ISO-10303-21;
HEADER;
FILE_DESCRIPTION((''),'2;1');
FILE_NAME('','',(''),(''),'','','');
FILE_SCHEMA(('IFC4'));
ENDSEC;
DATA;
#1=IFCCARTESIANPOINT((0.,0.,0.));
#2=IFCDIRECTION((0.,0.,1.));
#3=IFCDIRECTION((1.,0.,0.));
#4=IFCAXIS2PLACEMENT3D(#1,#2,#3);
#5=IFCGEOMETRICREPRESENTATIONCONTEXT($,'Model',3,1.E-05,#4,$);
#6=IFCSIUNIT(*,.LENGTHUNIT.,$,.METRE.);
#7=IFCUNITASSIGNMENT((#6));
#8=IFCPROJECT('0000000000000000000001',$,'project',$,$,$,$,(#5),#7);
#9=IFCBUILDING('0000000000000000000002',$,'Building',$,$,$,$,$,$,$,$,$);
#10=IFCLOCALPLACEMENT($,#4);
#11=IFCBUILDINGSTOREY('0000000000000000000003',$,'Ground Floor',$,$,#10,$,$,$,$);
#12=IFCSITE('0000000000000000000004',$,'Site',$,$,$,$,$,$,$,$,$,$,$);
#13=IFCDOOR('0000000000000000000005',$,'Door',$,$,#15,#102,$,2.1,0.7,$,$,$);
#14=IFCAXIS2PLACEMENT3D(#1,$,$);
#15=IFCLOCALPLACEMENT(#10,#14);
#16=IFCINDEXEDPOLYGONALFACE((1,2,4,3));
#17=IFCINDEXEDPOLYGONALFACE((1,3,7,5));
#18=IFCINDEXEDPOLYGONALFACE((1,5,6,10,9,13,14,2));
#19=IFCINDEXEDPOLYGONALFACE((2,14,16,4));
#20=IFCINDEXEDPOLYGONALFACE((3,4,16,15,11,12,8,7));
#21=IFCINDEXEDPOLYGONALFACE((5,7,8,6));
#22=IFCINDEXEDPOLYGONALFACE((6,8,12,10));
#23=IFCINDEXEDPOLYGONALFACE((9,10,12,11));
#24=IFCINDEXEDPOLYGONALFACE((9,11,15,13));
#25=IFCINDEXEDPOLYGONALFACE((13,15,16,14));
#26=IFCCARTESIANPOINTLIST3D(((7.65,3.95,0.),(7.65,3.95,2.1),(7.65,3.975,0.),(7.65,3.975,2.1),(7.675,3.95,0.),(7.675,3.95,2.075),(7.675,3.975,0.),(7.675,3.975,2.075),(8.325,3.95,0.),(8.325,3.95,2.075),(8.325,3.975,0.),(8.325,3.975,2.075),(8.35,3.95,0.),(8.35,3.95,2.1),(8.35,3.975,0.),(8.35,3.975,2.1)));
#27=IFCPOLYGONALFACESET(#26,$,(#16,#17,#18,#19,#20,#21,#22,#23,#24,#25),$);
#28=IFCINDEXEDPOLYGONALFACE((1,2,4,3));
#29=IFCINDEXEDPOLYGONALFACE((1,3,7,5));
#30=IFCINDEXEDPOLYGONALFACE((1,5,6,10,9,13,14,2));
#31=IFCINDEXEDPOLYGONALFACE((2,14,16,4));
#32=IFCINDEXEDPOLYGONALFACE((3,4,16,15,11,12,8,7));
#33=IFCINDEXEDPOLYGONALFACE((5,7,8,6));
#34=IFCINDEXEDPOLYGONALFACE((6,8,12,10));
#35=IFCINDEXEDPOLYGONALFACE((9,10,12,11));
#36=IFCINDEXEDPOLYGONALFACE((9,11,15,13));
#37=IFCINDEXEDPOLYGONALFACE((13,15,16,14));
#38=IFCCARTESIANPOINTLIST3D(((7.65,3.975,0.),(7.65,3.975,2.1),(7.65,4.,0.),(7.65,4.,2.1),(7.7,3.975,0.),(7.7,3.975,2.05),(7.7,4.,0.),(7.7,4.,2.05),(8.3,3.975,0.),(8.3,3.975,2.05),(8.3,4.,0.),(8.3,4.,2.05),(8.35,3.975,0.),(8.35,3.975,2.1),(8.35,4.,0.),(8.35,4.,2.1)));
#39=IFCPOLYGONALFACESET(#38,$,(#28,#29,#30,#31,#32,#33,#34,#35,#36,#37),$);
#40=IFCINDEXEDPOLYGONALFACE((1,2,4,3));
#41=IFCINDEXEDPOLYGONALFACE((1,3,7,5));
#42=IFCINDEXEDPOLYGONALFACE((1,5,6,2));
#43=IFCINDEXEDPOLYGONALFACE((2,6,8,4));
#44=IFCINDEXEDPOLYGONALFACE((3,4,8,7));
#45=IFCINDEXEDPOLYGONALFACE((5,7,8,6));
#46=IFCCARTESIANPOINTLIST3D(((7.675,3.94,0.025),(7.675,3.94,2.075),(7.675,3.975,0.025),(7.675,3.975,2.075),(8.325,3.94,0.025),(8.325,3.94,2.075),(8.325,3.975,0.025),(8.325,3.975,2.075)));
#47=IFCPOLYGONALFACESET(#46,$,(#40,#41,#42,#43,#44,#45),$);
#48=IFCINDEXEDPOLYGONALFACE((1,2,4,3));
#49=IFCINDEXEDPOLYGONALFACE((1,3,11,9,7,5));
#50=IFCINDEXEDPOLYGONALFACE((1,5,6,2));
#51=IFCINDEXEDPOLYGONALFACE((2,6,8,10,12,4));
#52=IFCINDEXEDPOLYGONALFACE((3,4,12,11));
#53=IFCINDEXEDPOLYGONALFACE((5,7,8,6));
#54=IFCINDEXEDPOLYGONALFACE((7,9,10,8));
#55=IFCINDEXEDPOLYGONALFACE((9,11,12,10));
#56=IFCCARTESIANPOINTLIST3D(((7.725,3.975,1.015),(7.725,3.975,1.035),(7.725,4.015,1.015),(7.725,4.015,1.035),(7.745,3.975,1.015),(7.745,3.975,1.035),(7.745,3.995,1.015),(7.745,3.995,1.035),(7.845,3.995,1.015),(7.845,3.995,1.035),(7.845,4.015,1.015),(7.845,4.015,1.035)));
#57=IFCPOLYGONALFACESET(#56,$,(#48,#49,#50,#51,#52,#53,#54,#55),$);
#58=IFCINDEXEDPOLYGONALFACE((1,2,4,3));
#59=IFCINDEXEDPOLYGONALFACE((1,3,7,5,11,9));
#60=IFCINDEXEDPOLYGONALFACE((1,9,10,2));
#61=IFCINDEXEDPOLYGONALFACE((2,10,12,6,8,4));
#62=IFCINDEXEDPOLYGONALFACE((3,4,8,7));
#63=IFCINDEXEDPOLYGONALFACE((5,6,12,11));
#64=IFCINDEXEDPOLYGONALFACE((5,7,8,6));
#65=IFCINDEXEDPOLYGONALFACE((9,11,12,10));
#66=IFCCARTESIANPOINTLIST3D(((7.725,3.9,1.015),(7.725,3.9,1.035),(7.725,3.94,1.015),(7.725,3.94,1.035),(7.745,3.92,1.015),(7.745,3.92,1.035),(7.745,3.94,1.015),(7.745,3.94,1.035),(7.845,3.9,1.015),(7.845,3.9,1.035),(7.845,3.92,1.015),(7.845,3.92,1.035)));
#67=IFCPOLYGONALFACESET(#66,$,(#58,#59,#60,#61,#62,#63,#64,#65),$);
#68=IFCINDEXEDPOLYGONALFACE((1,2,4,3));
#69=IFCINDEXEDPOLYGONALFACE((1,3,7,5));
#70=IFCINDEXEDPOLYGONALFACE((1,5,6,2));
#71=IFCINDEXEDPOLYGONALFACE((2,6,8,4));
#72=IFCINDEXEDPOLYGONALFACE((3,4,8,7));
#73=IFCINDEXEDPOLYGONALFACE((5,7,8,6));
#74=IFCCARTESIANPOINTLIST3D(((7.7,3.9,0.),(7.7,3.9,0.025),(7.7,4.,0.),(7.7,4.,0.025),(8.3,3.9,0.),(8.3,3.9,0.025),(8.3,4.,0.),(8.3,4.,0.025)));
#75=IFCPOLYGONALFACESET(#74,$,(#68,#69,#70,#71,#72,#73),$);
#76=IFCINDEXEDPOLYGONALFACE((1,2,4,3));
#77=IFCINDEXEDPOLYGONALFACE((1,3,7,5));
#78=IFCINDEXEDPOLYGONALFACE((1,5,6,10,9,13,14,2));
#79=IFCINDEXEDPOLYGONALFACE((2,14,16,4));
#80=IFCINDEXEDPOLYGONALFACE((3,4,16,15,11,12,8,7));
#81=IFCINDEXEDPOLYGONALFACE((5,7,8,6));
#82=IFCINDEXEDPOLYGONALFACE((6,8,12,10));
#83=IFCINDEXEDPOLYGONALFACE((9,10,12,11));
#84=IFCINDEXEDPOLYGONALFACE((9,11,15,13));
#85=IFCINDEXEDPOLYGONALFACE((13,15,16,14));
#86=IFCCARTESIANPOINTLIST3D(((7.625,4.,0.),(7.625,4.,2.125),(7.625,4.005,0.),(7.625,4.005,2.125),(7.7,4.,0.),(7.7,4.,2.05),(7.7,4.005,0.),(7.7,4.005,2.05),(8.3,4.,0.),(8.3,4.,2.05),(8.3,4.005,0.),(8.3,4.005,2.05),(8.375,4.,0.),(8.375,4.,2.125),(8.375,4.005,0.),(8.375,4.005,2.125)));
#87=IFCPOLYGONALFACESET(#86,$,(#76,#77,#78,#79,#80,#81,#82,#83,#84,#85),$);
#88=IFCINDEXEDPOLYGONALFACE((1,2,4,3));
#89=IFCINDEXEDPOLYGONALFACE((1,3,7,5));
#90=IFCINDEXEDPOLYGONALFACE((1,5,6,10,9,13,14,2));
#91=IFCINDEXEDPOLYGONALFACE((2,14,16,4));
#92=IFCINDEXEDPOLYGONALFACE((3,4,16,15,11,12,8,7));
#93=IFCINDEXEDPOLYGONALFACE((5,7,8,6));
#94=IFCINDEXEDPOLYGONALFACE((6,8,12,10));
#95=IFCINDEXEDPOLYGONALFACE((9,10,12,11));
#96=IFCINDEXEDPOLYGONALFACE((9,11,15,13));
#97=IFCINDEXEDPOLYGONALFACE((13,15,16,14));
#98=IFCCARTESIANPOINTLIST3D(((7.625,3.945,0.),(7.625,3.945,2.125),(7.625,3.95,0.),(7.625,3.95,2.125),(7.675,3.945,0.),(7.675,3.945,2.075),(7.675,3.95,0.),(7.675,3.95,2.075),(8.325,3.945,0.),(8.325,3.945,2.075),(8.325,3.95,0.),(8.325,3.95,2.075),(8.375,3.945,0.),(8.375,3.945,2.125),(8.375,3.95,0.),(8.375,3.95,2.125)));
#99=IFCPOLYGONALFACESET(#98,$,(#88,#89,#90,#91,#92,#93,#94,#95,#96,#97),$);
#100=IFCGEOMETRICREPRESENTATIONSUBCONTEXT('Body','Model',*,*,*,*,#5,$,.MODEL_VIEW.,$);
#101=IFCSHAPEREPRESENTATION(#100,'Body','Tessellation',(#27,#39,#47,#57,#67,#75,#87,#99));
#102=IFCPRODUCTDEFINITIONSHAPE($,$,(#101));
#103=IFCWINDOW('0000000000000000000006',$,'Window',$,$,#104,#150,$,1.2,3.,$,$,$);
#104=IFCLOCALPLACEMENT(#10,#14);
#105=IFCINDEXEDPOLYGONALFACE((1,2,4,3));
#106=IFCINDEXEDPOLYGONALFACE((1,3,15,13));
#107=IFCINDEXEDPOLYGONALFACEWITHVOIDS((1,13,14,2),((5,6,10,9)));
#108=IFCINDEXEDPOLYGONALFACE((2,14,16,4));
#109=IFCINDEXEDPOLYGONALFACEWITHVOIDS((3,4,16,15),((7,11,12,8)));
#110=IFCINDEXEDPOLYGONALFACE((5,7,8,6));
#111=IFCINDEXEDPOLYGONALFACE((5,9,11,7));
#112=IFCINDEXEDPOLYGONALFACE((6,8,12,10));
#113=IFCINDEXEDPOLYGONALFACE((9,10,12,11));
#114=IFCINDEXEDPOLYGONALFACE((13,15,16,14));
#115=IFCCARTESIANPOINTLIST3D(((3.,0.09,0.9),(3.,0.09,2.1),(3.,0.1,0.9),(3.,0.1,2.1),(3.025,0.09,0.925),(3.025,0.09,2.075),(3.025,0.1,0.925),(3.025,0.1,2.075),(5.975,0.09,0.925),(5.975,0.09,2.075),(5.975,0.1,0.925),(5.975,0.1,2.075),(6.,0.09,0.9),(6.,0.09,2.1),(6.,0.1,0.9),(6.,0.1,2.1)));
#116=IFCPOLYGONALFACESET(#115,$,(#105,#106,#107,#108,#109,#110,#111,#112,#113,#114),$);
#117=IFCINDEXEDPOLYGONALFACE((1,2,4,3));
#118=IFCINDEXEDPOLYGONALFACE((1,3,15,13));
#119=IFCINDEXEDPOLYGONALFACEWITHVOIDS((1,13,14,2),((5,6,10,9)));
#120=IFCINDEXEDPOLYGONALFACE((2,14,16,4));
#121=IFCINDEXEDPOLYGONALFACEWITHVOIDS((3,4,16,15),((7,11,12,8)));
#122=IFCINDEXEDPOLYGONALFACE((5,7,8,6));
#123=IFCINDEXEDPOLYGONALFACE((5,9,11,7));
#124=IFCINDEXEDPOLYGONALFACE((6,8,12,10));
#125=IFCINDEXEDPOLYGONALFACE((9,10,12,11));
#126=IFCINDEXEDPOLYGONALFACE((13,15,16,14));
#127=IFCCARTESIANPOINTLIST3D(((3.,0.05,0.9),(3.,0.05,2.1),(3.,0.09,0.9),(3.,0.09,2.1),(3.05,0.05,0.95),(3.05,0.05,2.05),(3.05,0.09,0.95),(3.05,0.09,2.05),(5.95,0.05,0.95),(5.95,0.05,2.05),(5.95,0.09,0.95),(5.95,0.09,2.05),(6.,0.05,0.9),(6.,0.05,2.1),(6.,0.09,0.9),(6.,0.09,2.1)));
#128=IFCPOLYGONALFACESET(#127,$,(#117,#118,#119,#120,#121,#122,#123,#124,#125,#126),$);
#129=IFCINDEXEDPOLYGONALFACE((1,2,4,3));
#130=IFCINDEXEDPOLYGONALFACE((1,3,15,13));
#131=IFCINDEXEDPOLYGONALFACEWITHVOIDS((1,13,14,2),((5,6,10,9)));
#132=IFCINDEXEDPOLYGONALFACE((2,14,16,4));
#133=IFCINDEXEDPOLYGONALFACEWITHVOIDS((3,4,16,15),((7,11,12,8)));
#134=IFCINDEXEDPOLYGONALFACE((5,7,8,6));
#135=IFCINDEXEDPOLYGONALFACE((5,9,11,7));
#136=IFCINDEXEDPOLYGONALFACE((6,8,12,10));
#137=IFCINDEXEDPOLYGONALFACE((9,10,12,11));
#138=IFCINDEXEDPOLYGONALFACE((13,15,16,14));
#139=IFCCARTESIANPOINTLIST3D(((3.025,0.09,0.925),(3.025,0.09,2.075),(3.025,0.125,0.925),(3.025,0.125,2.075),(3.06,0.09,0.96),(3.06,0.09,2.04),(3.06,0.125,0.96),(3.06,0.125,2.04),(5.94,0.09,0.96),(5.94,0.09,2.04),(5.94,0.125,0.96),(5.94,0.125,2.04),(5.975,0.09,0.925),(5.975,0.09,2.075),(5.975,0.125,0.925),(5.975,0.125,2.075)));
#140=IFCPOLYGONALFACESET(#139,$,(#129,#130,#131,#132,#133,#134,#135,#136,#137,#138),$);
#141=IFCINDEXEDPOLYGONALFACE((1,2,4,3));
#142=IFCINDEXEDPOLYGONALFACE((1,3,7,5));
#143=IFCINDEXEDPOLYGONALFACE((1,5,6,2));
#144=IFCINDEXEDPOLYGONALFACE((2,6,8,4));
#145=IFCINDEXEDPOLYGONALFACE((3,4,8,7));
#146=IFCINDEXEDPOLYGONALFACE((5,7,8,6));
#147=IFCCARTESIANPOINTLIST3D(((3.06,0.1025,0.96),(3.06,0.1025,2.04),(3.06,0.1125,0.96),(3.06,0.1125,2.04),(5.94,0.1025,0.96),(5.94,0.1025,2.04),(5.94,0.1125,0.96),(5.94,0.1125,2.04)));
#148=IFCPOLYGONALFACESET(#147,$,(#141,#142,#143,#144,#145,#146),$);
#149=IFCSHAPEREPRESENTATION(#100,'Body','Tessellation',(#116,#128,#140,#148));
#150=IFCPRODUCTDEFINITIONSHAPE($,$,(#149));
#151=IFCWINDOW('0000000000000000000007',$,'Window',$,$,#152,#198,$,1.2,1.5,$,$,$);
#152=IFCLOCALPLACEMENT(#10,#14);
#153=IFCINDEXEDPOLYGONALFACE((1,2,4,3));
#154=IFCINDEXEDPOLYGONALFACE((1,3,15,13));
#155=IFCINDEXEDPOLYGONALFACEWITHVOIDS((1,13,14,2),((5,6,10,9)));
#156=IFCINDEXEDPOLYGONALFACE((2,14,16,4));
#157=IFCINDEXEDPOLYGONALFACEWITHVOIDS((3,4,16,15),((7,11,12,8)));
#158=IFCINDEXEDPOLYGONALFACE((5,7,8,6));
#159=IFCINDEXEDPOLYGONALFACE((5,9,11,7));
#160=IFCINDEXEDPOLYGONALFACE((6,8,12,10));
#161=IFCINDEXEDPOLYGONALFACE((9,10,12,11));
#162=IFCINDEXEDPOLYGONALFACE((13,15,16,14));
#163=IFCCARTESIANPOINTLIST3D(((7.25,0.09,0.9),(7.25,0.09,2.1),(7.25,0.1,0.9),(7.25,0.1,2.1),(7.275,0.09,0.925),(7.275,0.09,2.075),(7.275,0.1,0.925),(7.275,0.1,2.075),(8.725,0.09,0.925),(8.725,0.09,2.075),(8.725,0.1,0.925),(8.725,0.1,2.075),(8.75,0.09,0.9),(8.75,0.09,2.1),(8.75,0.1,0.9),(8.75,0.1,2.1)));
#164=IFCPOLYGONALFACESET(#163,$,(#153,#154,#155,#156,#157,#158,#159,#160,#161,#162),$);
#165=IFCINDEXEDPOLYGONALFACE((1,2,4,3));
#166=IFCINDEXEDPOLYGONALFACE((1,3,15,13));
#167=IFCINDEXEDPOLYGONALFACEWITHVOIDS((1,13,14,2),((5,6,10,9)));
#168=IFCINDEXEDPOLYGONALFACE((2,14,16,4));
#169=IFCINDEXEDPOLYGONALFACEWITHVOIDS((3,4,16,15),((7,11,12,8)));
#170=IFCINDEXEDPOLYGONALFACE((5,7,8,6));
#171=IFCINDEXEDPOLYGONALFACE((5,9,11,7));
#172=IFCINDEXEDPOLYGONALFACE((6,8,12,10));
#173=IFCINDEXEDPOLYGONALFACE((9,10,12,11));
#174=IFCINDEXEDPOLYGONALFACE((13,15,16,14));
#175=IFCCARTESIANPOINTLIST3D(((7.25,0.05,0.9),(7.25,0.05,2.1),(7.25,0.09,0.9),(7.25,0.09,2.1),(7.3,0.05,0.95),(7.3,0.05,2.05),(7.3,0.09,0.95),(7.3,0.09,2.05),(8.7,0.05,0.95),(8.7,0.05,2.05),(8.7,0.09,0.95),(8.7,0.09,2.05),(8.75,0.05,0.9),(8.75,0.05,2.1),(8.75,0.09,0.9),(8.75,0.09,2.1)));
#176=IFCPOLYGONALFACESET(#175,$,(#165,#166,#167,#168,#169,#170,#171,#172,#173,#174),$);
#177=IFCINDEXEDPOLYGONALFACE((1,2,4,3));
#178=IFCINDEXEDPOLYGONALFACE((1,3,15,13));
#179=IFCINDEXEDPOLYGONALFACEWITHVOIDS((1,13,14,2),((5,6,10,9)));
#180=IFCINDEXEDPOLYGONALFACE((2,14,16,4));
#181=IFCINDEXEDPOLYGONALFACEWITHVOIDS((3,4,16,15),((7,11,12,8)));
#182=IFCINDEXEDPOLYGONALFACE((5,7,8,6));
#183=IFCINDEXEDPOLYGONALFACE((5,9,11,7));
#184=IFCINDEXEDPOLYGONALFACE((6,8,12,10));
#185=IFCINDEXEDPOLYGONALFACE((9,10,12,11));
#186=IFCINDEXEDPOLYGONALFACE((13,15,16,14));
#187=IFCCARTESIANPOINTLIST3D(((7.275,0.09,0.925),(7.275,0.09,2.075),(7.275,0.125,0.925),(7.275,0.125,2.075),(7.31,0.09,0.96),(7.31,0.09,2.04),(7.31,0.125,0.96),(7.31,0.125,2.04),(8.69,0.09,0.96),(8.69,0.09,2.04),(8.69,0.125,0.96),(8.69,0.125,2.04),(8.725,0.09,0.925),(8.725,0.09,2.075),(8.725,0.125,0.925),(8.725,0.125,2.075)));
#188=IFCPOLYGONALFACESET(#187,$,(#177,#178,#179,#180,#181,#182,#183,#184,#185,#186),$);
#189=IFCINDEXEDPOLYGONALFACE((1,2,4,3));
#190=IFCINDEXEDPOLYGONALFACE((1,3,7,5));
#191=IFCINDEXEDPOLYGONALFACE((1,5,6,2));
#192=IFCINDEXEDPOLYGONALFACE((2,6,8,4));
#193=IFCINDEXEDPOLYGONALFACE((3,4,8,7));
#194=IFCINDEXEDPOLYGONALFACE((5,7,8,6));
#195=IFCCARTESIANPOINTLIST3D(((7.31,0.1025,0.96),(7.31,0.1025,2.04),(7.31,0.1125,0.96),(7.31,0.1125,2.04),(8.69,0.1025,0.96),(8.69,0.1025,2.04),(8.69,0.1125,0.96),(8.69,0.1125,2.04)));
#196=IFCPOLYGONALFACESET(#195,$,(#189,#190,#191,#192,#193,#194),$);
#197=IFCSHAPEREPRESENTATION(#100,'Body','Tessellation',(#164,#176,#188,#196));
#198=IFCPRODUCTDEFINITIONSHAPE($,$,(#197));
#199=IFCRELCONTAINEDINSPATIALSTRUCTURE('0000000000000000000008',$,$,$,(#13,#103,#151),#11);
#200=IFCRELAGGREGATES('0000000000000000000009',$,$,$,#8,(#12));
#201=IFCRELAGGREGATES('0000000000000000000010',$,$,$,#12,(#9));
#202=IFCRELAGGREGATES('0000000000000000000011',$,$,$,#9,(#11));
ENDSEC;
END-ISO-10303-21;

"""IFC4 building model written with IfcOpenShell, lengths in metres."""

from ifc_helpers import new_model, si_unit, frame, origin_with_axes, place, context, subcontext, project, spatial, line, indexed_curve, outline, extrude, element, save


model = new_model("IFC4")

# Units and contexts
model_context = context("Model", 3, precision=1e-05, world=origin_with_axes())
body_context = subcontext(model_context, "Body", "Model", "MODEL_VIEW")
ifc_project = project(units=[si_unit("LENGTHUNIT", "METRE")], contexts=[model_context])

# Site, building, storey
site = spatial("IfcSite", under=ifc_project, Name="Site")
building = spatial("IfcBuilding", under=site, Name="Building")
storey_placement = place(None, origin_with_axes())
storey = spatial("IfcBuildingStorey", under=building, at=storey_placement, Name="Ground Floor")

# Door
door_1_placement = place(storey_placement, frame((8.35, 4.0, 0.0), z_axis=(0.0, 0.0, 1.0), x_axis=(-1.0, 0.0, 0.0)))
element("IfcDoor", 1, at=door_1_placement, inside=storey, Name="Door", OverallHeight=2.1, OverallWidth=0.7, context=body_context, shape_type="SweptSolid", body=[
    extrude(outline(indexed_curve([(0.0, 0.0), (0.0, 2.1), (0.7, 2.1), (0.7, 0.0), (0.675, 0.0), (0.675, 2.075), (0.025, 2.075), (0.025, 0.0)], segments=[line(1, 2, 3, 4, 5, 6, 7, 8, 1)])), frame((0.0, 0.025, 0.0), z_axis=(0.0, -1.0, 0.0), x_axis=(1.0, 0.0, 0.0)), (0.0, 0.0, -1.0), 0.025),
    extrude(outline(indexed_curve([(0.0, 0.0), (0.0, 2.1), (0.7, 2.1), (0.7, 0.0), (0.65, 0.0), (0.65, 2.05), (0.05, 2.05), (0.05, 0.0)], segments=[line(1, 2, 3, 4, 5, 6, 7, 8, 1)])), frame((0.0, 0.0, 0.0), z_axis=(0.0, -1.0, 0.0), x_axis=(1.0, 0.0, 0.0)), (0.0, 0.0, -1.0), 0.025),
    extrude(outline(indexed_curve([(0.0, 0.0), (0.65, 0.0), (0.65, 0.035), (0.0, 0.035)], segments=[line(1, 2, 3, 4, 1)])), frame((0.025, 0.025, 0.025), z_axis=(0.0, 0.0, 1.0), x_axis=(1.0, 0.0, 0.0)), (0.0, 0.0, 1.0), 2.05),
    extrude(outline(indexed_curve([(0.0, 0.0), (0.0, -0.04), (-0.12, -0.04), (-0.12, -0.02), (-0.02, -0.02), (-0.02, 0.0)], segments=[line(1, 2, 3, 4, 5, 6, 1)])), frame((0.625, 0.025, 1.015), z_axis=(0.0, 0.0, 1.0), x_axis=(1.0, 0.0, 0.0)), (0.0, 0.0, 1.0), 0.02),
    extrude(outline(indexed_curve([(0.0, 0.0), (0.0, 0.04), (-0.12, 0.04), (-0.12, 0.02), (-0.02, 0.02), (-0.02, 0.0)], segments=[line(1, 2, 3, 4, 5, 6, 1)])), frame((0.625, 0.06, 1.015), z_axis=(0.0, 0.0, 1.0), x_axis=(1.0, 0.0, 0.0)), (0.0, 0.0, 1.0), 0.02),
    extrude(outline(indexed_curve([(0.0, 0.0), (0.6, 0.0), (0.6, 0.1), (0.0, 0.1)], segments=[line(1, 2, 3, 4, 1)])), frame((0.05, 0.0, 0.0), z_axis=(0.0, 0.0, 1.0), x_axis=(1.0, 0.0, 0.0)), (0.0, 0.0, 1.0), 0.025),
    extrude(outline(indexed_curve([(0.0, 0.0), (0.0, 2.125), (0.75, 2.125), (0.75, 0.0), (0.675, 0.0), (0.675, 2.05), (0.075, 2.05), (0.075, 0.0)], segments=[line(1, 2, 3, 4, 5, 6, 7, 8, 1)])), frame((-0.025, -0.005, 0.0), z_axis=(0.0, -1.0, 0.0), x_axis=(1.0, 0.0, 0.0)), (0.0, 0.0, -1.0), 0.005),
    extrude(outline(indexed_curve([(0.0, 0.0), (0.0, 2.125), (0.75, 2.125), (0.75, 0.0), (0.7, 0.0), (0.7, 2.075), (0.05, 2.075), (0.05, 0.0)], segments=[line(1, 2, 3, 4, 5, 6, 7, 8, 1)])), frame((-0.025, 0.05, 0.0), z_axis=(0.0, -1.0, 0.0), x_axis=(1.0, 0.0, 0.0)), (0.0, 0.0, -1.0), 0.005),
])

# Windows
window_1_placement = place(storey_placement, frame((3.0, 0.0, 0.9), z_axis=(0.0, 0.0, 1.0), x_axis=(1.0, 0.0, 0.0)))
element("IfcWindow", 2, at=window_1_placement, inside=storey, Name="Window", OverallHeight=1.2, OverallWidth=3.0, context=body_context, shape_type="SweptSolid", body=[
    extrude(outline(indexed_curve([(0.0, 0.0), (3.0, 0.0), (3.0, 1.2), (0.0, 1.2)], segments=[line(1, 2, 3, 4, 1)]), holes=[indexed_curve([(0.025, 0.025), (2.975, 0.025), (2.975, 1.175), (0.025, 1.175)], segments=[line(1, 2, 3, 4, 1)])]), frame((0.0, 0.09, 0.0), z_axis=(0.0, -1.0, 0.0), x_axis=(1.0, 0.0, 0.0)), (0.0, 0.0, -1.0), 0.01),
    extrude(outline(indexed_curve([(0.0, 0.0), (3.0, 0.0), (3.0, 1.2), (0.0, 1.2)], segments=[line(1, 2, 3, 4, 1)]), holes=[indexed_curve([(0.05, 0.05), (2.95, 0.05), (2.95, 1.15), (0.05, 1.15)], segments=[line(1, 2, 3, 4, 1)])]), frame((0.0, 0.05, 0.0), z_axis=(0.0, -1.0, 0.0), x_axis=(1.0, 0.0, 0.0)), (0.0, 0.0, -1.0), 0.04),
    extrude(outline(indexed_curve([(0.0, 0.0), (2.95, 0.0), (2.95, 1.15), (0.0, 1.15)], segments=[line(1, 2, 3, 4, 1)]), holes=[indexed_curve([(0.035, 0.035), (2.915, 0.035), (2.915, 1.115), (0.035, 1.115)], segments=[line(1, 2, 3, 4, 1)])]), frame((0.025, 0.09, 0.025), z_axis=(0.0, -1.0, 0.0), x_axis=(1.0, 0.0, 0.0)), (0.0, 0.0, -1.0), 0.035),
    extrude(outline(indexed_curve([(0.035, 0.035), (2.915, 0.035), (2.915, 1.115), (0.035, 1.115)], segments=[line(1, 2, 3, 4, 1)])), frame((0.025, 0.1025, 0.025), z_axis=(0.0, -1.0, 0.0), x_axis=(1.0, 0.0, 0.0)), (0.0, 0.0, -1.0), 0.01),
])
for number, where, z_axis, x_axis, name in (
    (3, (7.25, 0.0, 0.9), (0.0, 0.0, 1.0), (1.0, 0.0, 0.0), "Window"),
):
    element("IfcWindow", number, at=place(storey_placement, frame(where, z_axis=z_axis, x_axis=x_axis)), inside=storey, Name=name, OverallHeight=1.2, OverallWidth=1.5, context=body_context, shape_type="SweptSolid", body=[
        extrude(outline(indexed_curve([(0.0, 0.0), (1.5, 0.0), (1.5, 1.2), (0.0, 1.2)], segments=[line(1, 2, 3, 4, 1)]), holes=[indexed_curve([(0.025, 0.025), (1.475, 0.025), (1.475, 1.175), (0.025, 1.175)], segments=[line(1, 2, 3, 4, 1)])]), frame((0.0, 0.09, 0.0), z_axis=(0.0, -1.0, 0.0), x_axis=(1.0, 0.0, 0.0)), (0.0, 0.0, -1.0), 0.01),
        extrude(outline(indexed_curve([(0.0, 0.0), (1.5, 0.0), (1.5, 1.2), (0.0, 1.2)], segments=[line(1, 2, 3, 4, 1)]), holes=[indexed_curve([(0.05, 0.05), (1.45, 0.05), (1.45, 1.15), (0.05, 1.15)], segments=[line(1, 2, 3, 4, 1)])]), frame((0.0, 0.05, 0.0), z_axis=(0.0, -1.0, 0.0), x_axis=(1.0, 0.0, 0.0)), (0.0, 0.0, -1.0), 0.04),
        extrude(outline(indexed_curve([(0.0, 0.0), (1.45, 0.0), (1.45, 1.15), (0.0, 1.15)], segments=[line(1, 2, 3, 4, 1)]), holes=[indexed_curve([(0.035, 0.035), (1.415, 0.035), (1.415, 1.115), (0.035, 1.115)], segments=[line(1, 2, 3, 4, 1)])]), frame((0.025, 0.09, 0.025), z_axis=(0.0, -1.0, 0.0), x_axis=(1.0, 0.0, 0.0)), (0.0, 0.0, -1.0), 0.035),
        extrude(outline(indexed_curve([(0.035, 0.035), (1.415, 0.035), (1.415, 1.115), (0.035, 1.115)], segments=[line(1, 2, 3, 4, 1)])), frame((0.025, 0.1025, 0.025), z_axis=(0.0, -1.0, 0.0), x_axis=(1.0, 0.0, 0.0)), (0.0, 0.0, -1.0), 0.01),
    ])

save(model, "model.ifc")
